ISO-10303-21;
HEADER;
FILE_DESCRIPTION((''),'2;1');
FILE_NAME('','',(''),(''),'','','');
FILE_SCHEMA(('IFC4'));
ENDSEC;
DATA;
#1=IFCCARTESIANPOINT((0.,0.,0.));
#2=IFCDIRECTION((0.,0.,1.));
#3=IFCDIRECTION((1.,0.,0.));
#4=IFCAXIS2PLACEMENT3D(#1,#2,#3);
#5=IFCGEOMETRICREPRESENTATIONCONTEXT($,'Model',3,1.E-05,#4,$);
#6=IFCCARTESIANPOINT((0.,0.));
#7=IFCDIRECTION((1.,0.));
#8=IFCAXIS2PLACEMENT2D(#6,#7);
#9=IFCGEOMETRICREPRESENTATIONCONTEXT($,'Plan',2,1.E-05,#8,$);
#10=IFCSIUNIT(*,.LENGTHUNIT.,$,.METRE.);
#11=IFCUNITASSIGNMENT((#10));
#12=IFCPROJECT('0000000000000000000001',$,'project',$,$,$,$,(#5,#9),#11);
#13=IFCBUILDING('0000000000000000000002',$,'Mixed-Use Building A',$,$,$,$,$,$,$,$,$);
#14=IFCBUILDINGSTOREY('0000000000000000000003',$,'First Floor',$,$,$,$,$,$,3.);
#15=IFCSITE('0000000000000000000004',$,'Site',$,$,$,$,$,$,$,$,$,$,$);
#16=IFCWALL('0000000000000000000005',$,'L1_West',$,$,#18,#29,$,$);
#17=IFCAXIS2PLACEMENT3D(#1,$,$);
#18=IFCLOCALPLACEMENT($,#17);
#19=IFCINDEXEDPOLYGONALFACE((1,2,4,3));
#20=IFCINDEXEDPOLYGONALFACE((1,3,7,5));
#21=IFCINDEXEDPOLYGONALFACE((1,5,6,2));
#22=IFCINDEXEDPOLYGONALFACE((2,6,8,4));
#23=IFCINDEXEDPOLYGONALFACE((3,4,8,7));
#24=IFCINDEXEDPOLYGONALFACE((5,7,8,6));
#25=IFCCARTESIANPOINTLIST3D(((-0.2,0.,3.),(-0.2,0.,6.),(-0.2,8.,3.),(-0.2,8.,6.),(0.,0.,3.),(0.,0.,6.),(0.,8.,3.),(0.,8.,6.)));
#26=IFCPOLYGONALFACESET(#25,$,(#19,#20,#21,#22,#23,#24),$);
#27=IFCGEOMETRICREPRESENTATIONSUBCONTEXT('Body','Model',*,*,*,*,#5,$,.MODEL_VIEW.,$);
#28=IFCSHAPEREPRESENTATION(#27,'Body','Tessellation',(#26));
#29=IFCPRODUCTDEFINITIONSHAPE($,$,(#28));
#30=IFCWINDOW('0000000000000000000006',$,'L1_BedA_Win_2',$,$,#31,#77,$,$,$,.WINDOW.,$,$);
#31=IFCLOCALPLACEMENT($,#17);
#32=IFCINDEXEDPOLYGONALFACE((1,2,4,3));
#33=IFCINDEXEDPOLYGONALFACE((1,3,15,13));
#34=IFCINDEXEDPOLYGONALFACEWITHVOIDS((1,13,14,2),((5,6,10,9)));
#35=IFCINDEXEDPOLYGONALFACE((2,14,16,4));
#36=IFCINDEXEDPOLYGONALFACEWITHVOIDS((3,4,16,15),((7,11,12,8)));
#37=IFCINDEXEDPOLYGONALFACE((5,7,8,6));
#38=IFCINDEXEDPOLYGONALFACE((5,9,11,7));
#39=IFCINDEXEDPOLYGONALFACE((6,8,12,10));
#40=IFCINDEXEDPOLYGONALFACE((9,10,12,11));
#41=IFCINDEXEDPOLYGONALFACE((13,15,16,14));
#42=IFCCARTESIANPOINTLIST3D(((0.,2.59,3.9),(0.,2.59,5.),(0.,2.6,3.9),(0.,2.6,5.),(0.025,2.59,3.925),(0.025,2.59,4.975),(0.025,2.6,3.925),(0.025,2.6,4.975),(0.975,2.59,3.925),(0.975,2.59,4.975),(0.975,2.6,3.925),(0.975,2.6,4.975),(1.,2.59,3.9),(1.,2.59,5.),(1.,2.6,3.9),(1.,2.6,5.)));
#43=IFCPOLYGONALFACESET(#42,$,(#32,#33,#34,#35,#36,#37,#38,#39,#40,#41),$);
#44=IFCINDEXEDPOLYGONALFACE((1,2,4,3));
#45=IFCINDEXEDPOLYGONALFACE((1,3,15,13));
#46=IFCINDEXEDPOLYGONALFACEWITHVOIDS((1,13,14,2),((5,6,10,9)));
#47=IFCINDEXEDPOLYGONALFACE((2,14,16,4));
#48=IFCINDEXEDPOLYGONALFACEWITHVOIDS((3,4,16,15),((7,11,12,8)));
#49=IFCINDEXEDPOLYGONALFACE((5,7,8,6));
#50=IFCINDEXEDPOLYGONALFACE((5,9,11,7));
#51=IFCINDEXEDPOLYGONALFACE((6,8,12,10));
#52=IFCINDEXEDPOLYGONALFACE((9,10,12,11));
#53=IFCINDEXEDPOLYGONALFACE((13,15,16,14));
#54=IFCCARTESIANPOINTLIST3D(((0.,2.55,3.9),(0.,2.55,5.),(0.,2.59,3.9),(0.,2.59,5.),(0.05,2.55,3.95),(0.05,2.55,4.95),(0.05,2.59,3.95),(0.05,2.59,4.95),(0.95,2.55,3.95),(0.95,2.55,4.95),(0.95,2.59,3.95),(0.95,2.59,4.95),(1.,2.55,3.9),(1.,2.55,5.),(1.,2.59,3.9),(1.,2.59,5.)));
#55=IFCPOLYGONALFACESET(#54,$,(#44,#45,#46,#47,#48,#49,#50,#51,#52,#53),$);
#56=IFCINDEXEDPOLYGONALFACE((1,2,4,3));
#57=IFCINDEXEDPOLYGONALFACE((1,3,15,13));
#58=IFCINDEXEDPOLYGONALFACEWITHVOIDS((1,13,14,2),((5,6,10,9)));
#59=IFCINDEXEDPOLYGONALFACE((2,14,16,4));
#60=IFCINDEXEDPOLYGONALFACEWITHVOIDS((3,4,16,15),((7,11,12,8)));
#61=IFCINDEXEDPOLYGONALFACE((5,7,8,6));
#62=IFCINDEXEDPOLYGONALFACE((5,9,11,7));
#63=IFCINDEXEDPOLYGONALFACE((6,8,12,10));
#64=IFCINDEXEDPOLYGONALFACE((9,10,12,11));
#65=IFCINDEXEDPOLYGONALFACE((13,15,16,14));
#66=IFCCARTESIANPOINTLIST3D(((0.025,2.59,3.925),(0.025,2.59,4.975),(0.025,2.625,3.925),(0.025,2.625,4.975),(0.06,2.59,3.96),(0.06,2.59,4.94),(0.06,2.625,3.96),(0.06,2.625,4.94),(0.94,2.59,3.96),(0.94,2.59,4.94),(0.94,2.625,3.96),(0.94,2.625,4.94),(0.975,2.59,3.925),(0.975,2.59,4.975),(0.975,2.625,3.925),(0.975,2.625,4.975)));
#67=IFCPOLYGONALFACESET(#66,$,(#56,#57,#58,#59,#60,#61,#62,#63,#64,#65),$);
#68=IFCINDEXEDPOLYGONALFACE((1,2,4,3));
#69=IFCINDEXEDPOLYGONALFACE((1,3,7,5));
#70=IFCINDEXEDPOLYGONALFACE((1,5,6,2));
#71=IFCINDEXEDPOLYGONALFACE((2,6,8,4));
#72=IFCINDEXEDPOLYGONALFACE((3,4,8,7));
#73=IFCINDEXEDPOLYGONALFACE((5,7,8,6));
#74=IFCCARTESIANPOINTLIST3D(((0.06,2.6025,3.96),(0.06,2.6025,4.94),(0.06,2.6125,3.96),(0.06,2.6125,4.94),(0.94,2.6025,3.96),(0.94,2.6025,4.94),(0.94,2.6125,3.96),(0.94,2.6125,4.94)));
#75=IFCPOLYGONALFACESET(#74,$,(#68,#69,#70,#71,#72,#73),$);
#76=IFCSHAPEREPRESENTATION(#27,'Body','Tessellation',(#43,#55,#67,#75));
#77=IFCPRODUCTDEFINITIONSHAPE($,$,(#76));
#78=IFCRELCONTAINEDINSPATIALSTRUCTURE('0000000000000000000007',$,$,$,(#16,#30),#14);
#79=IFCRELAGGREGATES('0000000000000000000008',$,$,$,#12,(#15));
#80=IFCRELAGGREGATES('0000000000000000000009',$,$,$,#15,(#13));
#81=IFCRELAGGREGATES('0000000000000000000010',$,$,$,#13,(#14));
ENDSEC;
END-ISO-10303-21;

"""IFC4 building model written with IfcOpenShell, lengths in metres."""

from ifc_helpers import new_model, si_unit, frame, origin_with_axes, origin_2d_with_axis, place, context, subcontext, project, spatial, line, indexed_curve, outline, extrude, element, fill, save


model = new_model("IFC4")

# Units and contexts
model_context = context("Model", 3, precision=1e-05, world=origin_with_axes())
plan_context = context("Plan", 2, precision=1e-05, world=origin_2d_with_axis())
body_context = subcontext(model_context, "Body", "Model", "MODEL_VIEW")
ifc_project = project(units=[si_unit("LENGTHUNIT", "METRE")], contexts=[model_context, plan_context])

# Site, building, storey
site = spatial("IfcSite", under=ifc_project, Name="Site")
building = spatial("IfcBuilding", under=site, Name="Mixed-Use Building A")
storey = spatial("IfcBuildingStorey", under=building, Name="First Floor", Elevation=3.0)

# Wall, opening, window
wall_1_placement = place(None, frame((0.0, 0.0, 3.0), z_axis=(0.0, 0.0, 1.0), x_axis=(0.0, 1.0, 0.0)))
wall_1 = element("IfcWall", 1, at=wall_1_placement, inside=storey, Name="L1_West", context=body_context, shape_type="SweptSolid", body=[
    extrude(outline(indexed_curve([(0.0, 0.0), (0.0, 0.2), (8.0, 0.2), (8.0, 0.0), (0.0, 0.0)], self_intersect=False)), origin_with_axes(), (0.0, 0.0, 1.0), 3.0),
])
opening_1_placement = place(wall_1_placement, frame((2.5, 0.0, 0.9), z_axis=(0.0, 0.0, 1.0), x_axis=(0.0, -1.0, 0.0)))
opening_1 = element("IfcOpeningElement", 2, at=opening_1_placement, inside=storey, cuts=wall_1, PredefinedType="OPENING", context=body_context, shape_type="SweptSolid", body=[
    extrude(outline(indexed_curve([(0.0, 0.0), (0.0, 0.3), (1.0, 0.3), (1.0, 0.0), (0.0, 0.0)], self_intersect=False)), origin_with_axes(), (0.0, 0.0, 1.0), 1.1),
])
window_1_placement = place(None, frame((0.0, 2.5, 3.9), z_axis=(0.0, 0.0, 1.0), x_axis=(1.0, 0.0, 0.0)))
window_1 = element("IfcWindow", 3, at=window_1_placement, inside=storey, Name="L1_BedA_Win_2", PredefinedType="WINDOW", context=body_context, shape_type="SweptSolid", body=[
    extrude(outline(indexed_curve([(0.0, 0.0), (1.0, 0.0), (1.0, 1.1), (0.0, 1.1)], segments=[line(1, 2, 3, 4, 1)]), holes=[indexed_curve([(0.025, 0.025), (0.975, 0.025), (0.975, 1.075), (0.025, 1.075)], segments=[line(1, 2, 3, 4, 1)])]), frame((0.0, 0.09, 0.0), z_axis=(0.0, -1.0, 0.0), x_axis=(1.0, 0.0, 0.0)), (0.0, 0.0, -1.0), 0.01),
    extrude(outline(indexed_curve([(0.0, 0.0), (1.0, 0.0), (1.0, 1.1), (0.0, 1.1)], segments=[line(1, 2, 3, 4, 1)]), holes=[indexed_curve([(0.05, 0.05), (0.95, 0.05), (0.95, 1.05), (0.05, 1.05)], segments=[line(1, 2, 3, 4, 1)])]), frame((0.0, 0.05, 0.0), z_axis=(0.0, -1.0, 0.0), x_axis=(1.0, 0.0, 0.0)), (0.0, 0.0, -1.0), 0.04),
    extrude(outline(indexed_curve([(0.0, 0.0), (0.95, 0.0), (0.95, 1.05), (0.0, 1.05)], segments=[line(1, 2, 3, 4, 1)]), holes=[indexed_curve([(0.035, 0.035), (0.915, 0.035), (0.915, 1.015), (0.035, 1.015)], segments=[line(1, 2, 3, 4, 1)])]), frame((0.025, 0.09, 0.025), z_axis=(0.0, -1.0, 0.0), x_axis=(1.0, 0.0, 0.0)), (0.0, 0.0, -1.0), 0.035),
    extrude(outline(indexed_curve([(0.035, 0.035), (0.915, 0.035), (0.915, 1.015), (0.035, 1.015)], segments=[line(1, 2, 3, 4, 1)])), frame((0.025, 0.1025, 0.025), z_axis=(0.0, -1.0, 0.0), x_axis=(1.0, 0.0, 0.0)), (0.0, 0.0, -1.0), 0.01),
])
fill(opening_1, window_1)

save(model, "model.ifc")
